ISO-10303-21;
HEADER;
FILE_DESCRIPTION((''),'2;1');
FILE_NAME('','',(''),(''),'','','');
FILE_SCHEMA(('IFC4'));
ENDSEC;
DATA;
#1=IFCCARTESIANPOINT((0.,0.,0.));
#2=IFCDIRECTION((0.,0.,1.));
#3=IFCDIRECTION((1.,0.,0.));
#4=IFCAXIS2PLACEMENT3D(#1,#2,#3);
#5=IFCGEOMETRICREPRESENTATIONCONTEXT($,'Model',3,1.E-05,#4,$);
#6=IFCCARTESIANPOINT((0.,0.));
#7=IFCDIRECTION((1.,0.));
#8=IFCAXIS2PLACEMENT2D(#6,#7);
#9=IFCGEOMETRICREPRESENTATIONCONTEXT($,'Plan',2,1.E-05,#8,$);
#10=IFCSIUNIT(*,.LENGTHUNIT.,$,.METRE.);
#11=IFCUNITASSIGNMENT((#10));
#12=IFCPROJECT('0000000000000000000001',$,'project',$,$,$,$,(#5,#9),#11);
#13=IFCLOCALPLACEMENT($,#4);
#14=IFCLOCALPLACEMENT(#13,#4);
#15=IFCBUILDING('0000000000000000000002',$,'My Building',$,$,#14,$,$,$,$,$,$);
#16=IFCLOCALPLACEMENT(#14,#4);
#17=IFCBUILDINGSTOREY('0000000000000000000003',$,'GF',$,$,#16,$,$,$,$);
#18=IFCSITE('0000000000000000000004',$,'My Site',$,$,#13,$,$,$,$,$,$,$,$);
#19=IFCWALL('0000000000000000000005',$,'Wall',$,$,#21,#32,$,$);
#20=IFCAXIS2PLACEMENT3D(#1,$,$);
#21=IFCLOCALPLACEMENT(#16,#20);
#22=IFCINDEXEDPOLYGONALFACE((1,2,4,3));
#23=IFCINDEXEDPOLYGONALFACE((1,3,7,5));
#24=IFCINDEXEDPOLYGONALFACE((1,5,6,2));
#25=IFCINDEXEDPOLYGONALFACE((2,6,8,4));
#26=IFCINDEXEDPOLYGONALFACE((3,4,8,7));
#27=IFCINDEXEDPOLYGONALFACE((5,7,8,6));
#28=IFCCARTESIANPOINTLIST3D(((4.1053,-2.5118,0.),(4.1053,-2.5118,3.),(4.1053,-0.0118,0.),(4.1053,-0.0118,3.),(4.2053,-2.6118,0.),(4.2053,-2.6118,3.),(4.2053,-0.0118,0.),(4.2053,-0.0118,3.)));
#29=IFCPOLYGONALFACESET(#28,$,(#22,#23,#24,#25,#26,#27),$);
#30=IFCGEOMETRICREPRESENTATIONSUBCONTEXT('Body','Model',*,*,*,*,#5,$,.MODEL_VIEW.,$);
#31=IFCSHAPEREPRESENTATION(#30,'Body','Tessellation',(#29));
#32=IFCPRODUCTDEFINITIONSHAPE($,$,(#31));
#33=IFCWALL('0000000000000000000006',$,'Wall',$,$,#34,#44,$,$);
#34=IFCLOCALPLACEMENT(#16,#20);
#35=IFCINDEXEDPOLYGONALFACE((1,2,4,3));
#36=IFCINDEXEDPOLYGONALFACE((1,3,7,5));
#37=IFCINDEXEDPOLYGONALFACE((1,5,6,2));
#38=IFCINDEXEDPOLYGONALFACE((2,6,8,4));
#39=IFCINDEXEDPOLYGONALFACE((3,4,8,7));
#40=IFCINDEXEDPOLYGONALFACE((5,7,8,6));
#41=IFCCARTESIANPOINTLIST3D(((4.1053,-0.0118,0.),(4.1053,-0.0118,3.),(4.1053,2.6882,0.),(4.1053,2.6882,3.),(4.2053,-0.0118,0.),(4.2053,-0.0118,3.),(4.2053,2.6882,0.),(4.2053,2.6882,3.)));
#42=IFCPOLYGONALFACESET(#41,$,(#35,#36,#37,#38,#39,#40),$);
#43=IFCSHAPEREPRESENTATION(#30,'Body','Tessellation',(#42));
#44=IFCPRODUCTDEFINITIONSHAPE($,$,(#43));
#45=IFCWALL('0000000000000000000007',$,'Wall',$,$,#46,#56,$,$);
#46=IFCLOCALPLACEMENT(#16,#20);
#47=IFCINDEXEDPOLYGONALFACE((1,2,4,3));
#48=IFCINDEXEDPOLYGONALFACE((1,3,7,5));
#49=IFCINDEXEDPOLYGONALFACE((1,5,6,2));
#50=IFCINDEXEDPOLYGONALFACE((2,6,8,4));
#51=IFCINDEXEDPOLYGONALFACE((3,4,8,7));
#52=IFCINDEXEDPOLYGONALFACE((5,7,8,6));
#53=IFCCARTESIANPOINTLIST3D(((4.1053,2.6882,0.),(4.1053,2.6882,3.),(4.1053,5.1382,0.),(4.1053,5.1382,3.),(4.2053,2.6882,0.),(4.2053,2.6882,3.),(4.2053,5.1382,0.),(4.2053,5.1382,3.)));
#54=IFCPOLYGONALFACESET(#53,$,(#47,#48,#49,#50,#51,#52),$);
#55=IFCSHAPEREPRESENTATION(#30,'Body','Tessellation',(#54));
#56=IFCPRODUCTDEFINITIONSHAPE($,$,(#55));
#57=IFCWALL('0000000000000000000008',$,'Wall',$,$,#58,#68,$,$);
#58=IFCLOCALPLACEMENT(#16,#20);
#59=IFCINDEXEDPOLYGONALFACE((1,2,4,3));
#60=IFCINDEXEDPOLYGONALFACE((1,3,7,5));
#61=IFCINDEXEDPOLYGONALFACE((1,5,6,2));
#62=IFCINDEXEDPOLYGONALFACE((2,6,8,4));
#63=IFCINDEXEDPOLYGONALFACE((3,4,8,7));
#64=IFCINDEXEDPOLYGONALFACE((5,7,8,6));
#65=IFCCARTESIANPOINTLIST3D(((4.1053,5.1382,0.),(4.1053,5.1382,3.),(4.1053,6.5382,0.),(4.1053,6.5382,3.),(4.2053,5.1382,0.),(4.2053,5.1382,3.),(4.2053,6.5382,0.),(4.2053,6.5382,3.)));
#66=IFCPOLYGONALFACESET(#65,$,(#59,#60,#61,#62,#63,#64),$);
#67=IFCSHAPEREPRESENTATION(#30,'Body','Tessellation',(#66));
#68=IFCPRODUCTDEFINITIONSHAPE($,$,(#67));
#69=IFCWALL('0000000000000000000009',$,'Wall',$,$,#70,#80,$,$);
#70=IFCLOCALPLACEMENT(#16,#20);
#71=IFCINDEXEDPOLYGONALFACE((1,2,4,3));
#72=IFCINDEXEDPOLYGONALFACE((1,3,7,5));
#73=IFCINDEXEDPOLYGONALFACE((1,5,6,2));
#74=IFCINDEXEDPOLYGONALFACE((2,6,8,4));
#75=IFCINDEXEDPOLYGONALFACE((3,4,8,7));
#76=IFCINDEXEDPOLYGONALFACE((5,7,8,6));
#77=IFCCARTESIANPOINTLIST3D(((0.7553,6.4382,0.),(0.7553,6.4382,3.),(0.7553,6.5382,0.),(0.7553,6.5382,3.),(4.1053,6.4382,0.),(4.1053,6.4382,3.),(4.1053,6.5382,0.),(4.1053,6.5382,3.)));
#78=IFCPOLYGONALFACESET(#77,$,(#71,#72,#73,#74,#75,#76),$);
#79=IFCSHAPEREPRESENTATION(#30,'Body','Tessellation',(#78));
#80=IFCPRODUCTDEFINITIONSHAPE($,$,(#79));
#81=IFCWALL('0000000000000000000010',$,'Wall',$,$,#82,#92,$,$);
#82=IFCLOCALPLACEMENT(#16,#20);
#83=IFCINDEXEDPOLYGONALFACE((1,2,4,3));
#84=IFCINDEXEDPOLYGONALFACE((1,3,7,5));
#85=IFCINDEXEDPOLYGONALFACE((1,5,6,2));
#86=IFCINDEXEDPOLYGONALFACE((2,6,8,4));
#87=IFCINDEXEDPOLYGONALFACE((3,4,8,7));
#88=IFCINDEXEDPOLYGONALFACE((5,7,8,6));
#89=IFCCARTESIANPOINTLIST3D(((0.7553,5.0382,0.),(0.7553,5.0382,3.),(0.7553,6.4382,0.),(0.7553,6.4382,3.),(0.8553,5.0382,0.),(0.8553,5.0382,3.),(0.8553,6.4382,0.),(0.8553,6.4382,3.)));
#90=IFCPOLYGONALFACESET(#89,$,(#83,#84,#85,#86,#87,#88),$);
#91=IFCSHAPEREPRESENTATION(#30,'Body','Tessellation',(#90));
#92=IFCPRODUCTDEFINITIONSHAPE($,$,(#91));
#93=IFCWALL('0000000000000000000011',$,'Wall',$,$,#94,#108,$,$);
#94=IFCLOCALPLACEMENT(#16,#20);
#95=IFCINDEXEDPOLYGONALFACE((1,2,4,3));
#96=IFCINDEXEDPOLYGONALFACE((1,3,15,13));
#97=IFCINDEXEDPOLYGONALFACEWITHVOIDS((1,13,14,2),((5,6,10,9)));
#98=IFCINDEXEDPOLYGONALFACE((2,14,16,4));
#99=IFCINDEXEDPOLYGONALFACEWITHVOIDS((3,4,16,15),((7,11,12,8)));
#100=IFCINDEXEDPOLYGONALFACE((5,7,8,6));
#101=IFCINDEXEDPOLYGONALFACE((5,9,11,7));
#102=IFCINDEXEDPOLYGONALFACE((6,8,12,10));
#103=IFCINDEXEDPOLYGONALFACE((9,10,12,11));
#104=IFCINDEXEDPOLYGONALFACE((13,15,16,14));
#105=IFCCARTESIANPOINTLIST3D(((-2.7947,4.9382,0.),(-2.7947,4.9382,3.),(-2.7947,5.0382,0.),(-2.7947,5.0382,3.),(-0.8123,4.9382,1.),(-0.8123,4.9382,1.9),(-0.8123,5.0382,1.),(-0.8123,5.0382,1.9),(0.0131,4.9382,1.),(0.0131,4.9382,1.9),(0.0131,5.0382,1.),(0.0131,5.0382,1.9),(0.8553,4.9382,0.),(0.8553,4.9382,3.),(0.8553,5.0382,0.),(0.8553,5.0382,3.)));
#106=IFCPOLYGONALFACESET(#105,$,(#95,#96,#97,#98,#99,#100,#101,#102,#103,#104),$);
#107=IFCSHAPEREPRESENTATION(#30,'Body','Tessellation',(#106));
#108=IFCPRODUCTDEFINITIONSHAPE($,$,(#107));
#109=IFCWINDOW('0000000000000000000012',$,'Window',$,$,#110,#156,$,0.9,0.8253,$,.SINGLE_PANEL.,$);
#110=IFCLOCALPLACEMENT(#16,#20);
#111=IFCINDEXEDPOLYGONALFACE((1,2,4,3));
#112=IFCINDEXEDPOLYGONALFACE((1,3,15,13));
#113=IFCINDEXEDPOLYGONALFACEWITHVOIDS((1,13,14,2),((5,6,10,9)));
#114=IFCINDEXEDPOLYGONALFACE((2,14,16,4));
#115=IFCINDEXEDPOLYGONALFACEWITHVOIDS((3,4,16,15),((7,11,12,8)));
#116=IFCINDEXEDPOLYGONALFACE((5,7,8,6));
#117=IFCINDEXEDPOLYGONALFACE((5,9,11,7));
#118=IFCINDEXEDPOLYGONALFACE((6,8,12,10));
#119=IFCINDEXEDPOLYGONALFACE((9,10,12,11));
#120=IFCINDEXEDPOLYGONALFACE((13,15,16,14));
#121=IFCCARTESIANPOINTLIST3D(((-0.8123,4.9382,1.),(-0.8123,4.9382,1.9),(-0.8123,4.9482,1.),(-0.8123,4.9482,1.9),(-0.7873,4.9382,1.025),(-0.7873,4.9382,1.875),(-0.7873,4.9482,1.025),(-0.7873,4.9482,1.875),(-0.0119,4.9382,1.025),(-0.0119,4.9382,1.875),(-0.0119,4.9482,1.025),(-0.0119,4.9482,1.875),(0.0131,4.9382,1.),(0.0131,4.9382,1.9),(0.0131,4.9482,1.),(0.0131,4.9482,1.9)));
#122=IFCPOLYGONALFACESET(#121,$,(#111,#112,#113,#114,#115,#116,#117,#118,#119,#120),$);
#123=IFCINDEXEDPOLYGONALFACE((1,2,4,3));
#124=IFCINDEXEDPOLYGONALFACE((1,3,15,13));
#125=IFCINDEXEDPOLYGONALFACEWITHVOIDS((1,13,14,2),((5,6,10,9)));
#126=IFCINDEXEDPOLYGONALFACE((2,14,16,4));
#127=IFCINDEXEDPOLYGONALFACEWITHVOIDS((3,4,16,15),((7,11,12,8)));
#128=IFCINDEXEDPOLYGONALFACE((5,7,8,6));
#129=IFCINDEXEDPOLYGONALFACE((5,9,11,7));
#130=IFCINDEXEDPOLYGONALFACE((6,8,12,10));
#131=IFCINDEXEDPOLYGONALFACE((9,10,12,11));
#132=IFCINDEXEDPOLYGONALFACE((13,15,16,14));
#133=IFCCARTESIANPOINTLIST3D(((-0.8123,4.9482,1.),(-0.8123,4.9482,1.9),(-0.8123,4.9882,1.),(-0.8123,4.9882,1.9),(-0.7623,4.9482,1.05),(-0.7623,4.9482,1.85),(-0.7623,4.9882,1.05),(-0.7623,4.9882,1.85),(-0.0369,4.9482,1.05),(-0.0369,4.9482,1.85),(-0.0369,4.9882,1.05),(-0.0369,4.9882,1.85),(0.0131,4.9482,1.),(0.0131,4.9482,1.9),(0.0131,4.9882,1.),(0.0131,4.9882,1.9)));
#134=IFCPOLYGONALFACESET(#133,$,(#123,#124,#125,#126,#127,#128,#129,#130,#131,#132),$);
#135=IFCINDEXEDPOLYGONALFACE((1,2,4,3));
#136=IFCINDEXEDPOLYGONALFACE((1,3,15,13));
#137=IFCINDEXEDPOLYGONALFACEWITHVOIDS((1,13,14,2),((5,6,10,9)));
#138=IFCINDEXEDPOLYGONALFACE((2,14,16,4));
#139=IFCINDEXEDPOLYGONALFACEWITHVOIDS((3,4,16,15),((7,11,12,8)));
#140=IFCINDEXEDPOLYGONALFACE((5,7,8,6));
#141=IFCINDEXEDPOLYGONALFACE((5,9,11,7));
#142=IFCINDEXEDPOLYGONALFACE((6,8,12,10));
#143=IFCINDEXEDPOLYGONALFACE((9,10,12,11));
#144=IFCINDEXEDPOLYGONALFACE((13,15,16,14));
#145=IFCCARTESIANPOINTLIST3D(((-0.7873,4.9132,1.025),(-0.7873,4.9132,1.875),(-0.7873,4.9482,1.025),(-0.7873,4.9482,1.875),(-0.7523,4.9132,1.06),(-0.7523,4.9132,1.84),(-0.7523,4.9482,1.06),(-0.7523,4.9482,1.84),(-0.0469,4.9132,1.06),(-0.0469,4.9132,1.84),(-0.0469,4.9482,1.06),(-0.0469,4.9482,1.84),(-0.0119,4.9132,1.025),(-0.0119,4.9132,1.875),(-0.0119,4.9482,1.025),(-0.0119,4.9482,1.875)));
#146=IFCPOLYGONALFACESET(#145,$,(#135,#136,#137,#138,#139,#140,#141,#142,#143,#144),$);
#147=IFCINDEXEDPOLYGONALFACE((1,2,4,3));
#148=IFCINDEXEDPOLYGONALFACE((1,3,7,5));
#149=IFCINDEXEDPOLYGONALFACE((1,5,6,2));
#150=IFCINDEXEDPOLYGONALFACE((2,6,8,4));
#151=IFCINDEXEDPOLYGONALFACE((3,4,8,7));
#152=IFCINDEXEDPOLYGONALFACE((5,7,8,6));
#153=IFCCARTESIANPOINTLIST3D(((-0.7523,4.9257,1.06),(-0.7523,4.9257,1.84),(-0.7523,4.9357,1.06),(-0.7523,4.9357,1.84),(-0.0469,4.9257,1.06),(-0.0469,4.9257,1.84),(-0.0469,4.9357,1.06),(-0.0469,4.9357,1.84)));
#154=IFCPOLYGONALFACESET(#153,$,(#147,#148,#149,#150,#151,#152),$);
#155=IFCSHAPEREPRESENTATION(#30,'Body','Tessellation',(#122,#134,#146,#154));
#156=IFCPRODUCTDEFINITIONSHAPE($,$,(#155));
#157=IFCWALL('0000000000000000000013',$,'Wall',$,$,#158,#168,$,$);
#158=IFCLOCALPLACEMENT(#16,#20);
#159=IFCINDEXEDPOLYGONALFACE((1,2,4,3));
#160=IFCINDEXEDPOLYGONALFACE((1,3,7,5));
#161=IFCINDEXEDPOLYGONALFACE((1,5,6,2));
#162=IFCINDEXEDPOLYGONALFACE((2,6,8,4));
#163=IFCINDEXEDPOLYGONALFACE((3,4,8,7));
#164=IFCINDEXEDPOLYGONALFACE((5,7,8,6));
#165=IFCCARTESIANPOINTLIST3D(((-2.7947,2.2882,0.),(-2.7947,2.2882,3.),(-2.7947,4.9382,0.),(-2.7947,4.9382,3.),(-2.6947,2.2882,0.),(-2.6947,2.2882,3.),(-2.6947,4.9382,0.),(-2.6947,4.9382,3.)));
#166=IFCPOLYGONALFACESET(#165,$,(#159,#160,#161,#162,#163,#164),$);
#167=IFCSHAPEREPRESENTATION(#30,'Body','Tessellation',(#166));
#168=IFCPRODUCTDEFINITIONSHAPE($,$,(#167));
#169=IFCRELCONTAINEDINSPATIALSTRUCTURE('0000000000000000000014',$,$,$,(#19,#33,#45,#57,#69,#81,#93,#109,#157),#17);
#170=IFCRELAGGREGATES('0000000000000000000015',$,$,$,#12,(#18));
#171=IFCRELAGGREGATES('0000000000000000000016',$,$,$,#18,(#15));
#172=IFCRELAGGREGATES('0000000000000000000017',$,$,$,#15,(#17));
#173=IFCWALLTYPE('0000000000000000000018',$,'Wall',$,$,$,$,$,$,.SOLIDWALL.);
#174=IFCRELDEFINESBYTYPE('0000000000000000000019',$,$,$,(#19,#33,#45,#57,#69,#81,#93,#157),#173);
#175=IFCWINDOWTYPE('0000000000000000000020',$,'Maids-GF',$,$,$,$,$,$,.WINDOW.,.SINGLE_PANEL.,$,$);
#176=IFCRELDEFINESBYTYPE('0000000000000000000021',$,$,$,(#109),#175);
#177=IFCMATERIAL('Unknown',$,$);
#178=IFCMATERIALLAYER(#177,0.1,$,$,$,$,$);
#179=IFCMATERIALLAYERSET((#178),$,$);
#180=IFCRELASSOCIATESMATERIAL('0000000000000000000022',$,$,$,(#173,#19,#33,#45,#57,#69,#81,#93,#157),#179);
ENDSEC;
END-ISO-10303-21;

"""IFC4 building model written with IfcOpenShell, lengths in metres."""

from ifc_helpers import new_model, entity, si_unit, frame, origin_with_axes, origin_2d_with_axis, place, context, subcontext, project, spatial, line, indexed_curve, outline, extrude, shape, source, transform, mapped, material, layer, layer_set, layer_usage, type_object, type_shapes, element, fill, save


model = new_model("IFC4")

# Units and contexts
model_context = context("Model", 3, precision=1e-05, world=origin_with_axes())
plan_context = context("Plan", 2, precision=1e-05, world=origin_2d_with_axis())
body_context_1 = subcontext(model_context, "Body", "Model", "MODEL_VIEW")
body_context_2 = subcontext(plan_context, "Body", "Plan", "PLAN_VIEW")
ifc_project = project(units=[si_unit("LENGTHUNIT", "METRE")], contexts=[model_context, plan_context])

# Site, building, storey
site_placement = place(None, origin_with_axes())
site = spatial("IfcSite", under=ifc_project, at=site_placement, Name="My Site")
building_placement = place(site_placement, origin_with_axes())
building = spatial("IfcBuilding", under=site, at=building_placement, Name="My Building")
storey_placement = place(building_placement, origin_with_axes())
storey = spatial("IfcBuildingStorey", under=building, at=storey_placement, Name="GF")

# Shared definitions
ifc_material = material(Name="Unknown")

# Shared definitions
ifc_layer_1 = layer(ifc_material, 0.1)
ifc_layer_set_1 = layer_set([ifc_layer_1])
wall_type = type_object("IfcWallType", Name="Wall", PredefinedType="SOLIDWALL", material=ifc_layer_set_1)

# Walls
ifc_layer_usage_1 = layer_usage(ifc_layer_set_1, "AXIS2", "POSITIVE", 0.0)
wall_1_placement = place(storey_placement, frame((4.2053, -2.6118, 0.0), z_axis=(0.0, 0.0, 1.0), x_axis=(0.0, 1.0, 0.0)))
element("IfcWall", 1, at=wall_1_placement, inside=storey, type_object=wall_type, material=ifc_layer_usage_1, Name="Wall", context=body_context_1, shape_type="SweptSolid", body=[
    extrude(outline(indexed_curve([(0.0, 0.0), (0.1, 0.1), (2.6, 0.1), (2.6, 0.0)], segments=[line(1, 2, 3, 4, 1)])), origin_with_axes(), (0.0, 0.0, 1.0), 3.0),
])
ifc_layer_usage_2 = layer_usage(ifc_layer_set_1, "AXIS2", "POSITIVE", 0.0)
wall_2_placement = place(storey_placement, frame((4.2053, -0.0118, 0.0), z_axis=(0.0, 0.0, 1.0), x_axis=(0.0, 1.0, 0.0)))
element("IfcWall", 2, at=wall_2_placement, inside=storey, type_object=wall_type, material=ifc_layer_usage_2, Name="Wall", context=body_context_1, shape_type="SweptSolid", body=[
    extrude(outline(indexed_curve([(0.0, 0.0), (0.0, 0.1), (2.7, 0.1), (2.7, 0.0)], segments=[line(1, 2, 3, 4, 1)])), origin_with_axes(), (0.0, 0.0, 1.0), 3.0),
])
ifc_layer_usage_3 = layer_usage(ifc_layer_set_1, "AXIS2", "POSITIVE", 0.0)
wall_3_placement = place(storey_placement, frame((4.2053, 2.6882, 0.0), z_axis=(0.0, 0.0, 1.0), x_axis=(0.0, 1.0, 0.0)))
element("IfcWall", 3, at=wall_3_placement, inside=storey, type_object=wall_type, material=ifc_layer_usage_3, Name="Wall", context=body_context_1, shape_type="SweptSolid", body=[
    extrude(outline(indexed_curve([(0.0, 0.0), (0.0, 0.1), (2.45, 0.1), (2.45, 0.0)], segments=[line(1, 2, 3, 4, 1)])), origin_with_axes(), (0.0, 0.0, 1.0), 3.0),
])
ifc_layer_usage_4 = layer_usage(ifc_layer_set_1, "AXIS2", "POSITIVE", 0.0)
wall_4_placement = place(storey_placement, frame((4.2053, 5.1382, 0.0), z_axis=(0.0, 0.0, 1.0), x_axis=(0.0, 1.0, 0.0)))
element("IfcWall", 4, at=wall_4_placement, inside=storey, type_object=wall_type, material=ifc_layer_usage_4, Name="Wall", context=body_context_1, shape_type="SweptSolid", body=[
    extrude(outline(indexed_curve([(0.0, 0.0), (0.0, 0.1), (1.4, 0.1), (1.4, 0.0)], segments=[line(1, 2, 3, 4, 1)])), origin_with_axes(), (0.0, 0.0, 1.0), 3.0),
])
ifc_layer_usage_5 = layer_usage(ifc_layer_set_1, "AXIS2", "POSITIVE", 0.0)
wall_5_placement = place(storey_placement, frame((4.1053, 6.5382, 0.0), z_axis=(0.0, 0.0, 1.0), x_axis=(-1.0, 0.0, 0.0)))
element("IfcWall", 5, at=wall_5_placement, inside=storey, type_object=wall_type, material=ifc_layer_usage_5, Name="Wall", context=body_context_1, shape_type="SweptSolid", body=[
    extrude(outline(indexed_curve([(0.0, 0.0), (0.0, 0.1), (3.35, 0.1), (3.35, 0.0)], segments=[line(1, 2, 3, 4, 1)])), origin_with_axes(), (0.0, 0.0, 1.0), 3.0),
])
ifc_layer_usage_6 = layer_usage(ifc_layer_set_1, "AXIS2", "POSITIVE", 0.0)
wall_6_placement = place(storey_placement, frame((0.7553, 6.4382, 0.0), z_axis=(0.0, 0.0, 1.0), x_axis=(0.0, -1.0, 0.0)))
element("IfcWall", 6, at=wall_6_placement, inside=storey, type_object=wall_type, material=ifc_layer_usage_6, Name="Wall", context=body_context_1, shape_type="SweptSolid", body=[
    extrude(outline(indexed_curve([(0.0, 0.0), (0.0, 0.1), (1.4, 0.1), (1.4, 0.0)], segments=[line(1, 2, 3, 4, 1)])), origin_with_axes(), (0.0, 0.0, 1.0), 3.0),
])

# Wall, opening, window
ifc_layer_usage_7 = layer_usage(ifc_layer_set_1, "AXIS2", "POSITIVE", 0.0)
wall_7_placement = place(storey_placement, frame((0.8553, 5.0382, 0.0), z_axis=(0.0, 0.0, 1.0), x_axis=(-1.0, 0.0, 0.0)))
wall_7 = element("IfcWall", 7, at=wall_7_placement, inside=storey, type_object=wall_type, material=ifc_layer_usage_7, Name="Wall", context=body_context_1, shape_type="SweptSolid", body=[
    extrude(outline(indexed_curve([(0.0, 0.0), (0.0, 0.1), (3.65, 0.1), (3.65, 0.0)], segments=[line(1, 2, 3, 4, 1)])), origin_with_axes(), (0.0, 0.0, 1.0), 3.0),
])
shared_shape_1 = source(origin_with_axes(), body_context_1, "Body", "SweptSolid", [
    extrude(outline(indexed_curve([(0.0, 0.0), (0.8253, 0.0), (0.8253, 0.9), (0.0, 0.9)], segments=[line(1, 2, 3, 4, 1)])), frame((0.0, -0.6, 0.0), z_axis=(0.0, -1.0, 0.0), x_axis=(1.0, 0.0, 0.0)), (0.0, 0.0, -1.0), 1.2),
])
opening_1_placement = place(wall_7_placement, frame((0.8422, 0.0, 1.0), z_axis=(0.0, 0.0, 1.0), x_axis=(1.0, -0.000001, 0.0)))
opening_1 = element("IfcOpeningElement", 8, at=opening_1_placement, cuts=wall_7, PredefinedType="OPENING", context=body_context_1, shape_type="MappedRepresentation", body=[
    mapped(shared_shape_1, transform((0.0, 0.0, 0.0), x_axis=(1.0, 0.0, 0.0), y_axis=(0.0, 1.0, 0.0), z_axis=(0.0, 0.0, 1.0), scale=1.0)),
])
window_type_1 = type_object("IfcWindowType", Name="Maids-GF", PartitioningType="SINGLE_PANEL", PredefinedType="WINDOW")
shared_shape_2 = source(origin_with_axes(), body_context_1, "Body", "SweptSolid", [
    extrude(outline(indexed_curve([(0.0, 0.0), (0.8253, 0.0), (0.8253, 0.9), (0.0, 0.9)], segments=[line(1, 2, 3, 4, 1)]), holes=[indexed_curve([(0.025, 0.025), (0.8003, 0.025), (0.8003, 0.875), (0.025, 0.875)], segments=[line(1, 2, 3, 4, 1)])]), frame((0.0, 0.09, 0.0), z_axis=(0.0, -1.0, 0.0), x_axis=(1.0, 0.0, 0.0)), (0.0, 0.0, -1.0), 0.01),
    extrude(outline(indexed_curve([(0.0, 0.0), (0.8253, 0.0), (0.8253, 0.9), (0.0, 0.9)], segments=[line(1, 2, 3, 4, 1)]), holes=[indexed_curve([(0.05, 0.05), (0.7753, 0.05), (0.7753, 0.85), (0.05, 0.85)], segments=[line(1, 2, 3, 4, 1)])]), frame((0.0, 0.05, 0.0), z_axis=(0.0, -1.0, 0.0), x_axis=(1.0, 0.0, 0.0)), (0.0, 0.0, -1.0), 0.04),
    extrude(outline(indexed_curve([(0.0, 0.0), (0.7753, 0.0), (0.7753, 0.85), (0.0, 0.85)], segments=[line(1, 2, 3, 4, 1)]), holes=[indexed_curve([(0.035, 0.035), (0.7403, 0.035), (0.7403, 0.815), (0.035, 0.815)], segments=[line(1, 2, 3, 4, 1)])]), frame((0.025, 0.09, 0.025), z_axis=(0.0, -1.0, 0.0), x_axis=(1.0, 0.0, 0.0)), (0.0, 0.0, -1.0), 0.035),
    extrude(outline(indexed_curve([(0.035, 0.035), (0.7403, 0.035), (0.7403, 0.815), (0.035, 0.815)], segments=[line(1, 2, 3, 4, 1)])), frame((0.025, 0.1025, 0.025), z_axis=(0.0, -1.0, 0.0), x_axis=(1.0, 0.0, 0.0)), (0.0, 0.0, -1.0), 0.01),
])
shared_shape_3 = source(origin_with_axes(), body_context_2, "Body", "Curve2D", [
    entity("IfcIndexedPolyCurve", entity("IfcCartesianPointList2D", [[0.05, 0.05], [0.7753, 0.05]])),
    entity("IfcIndexedPolyCurve", entity("IfcCartesianPointList2D", [[0.0, 0.1], [0.025, 0.1], [0.025, 0.09], [0.05, 0.09], [0.05, 0.05], [0.0, 0.05]]), [entity("IfcLineIndex", [1, 2, 3, 4, 5, 6, 1])]),
    entity("IfcIndexedPolyCurve", entity("IfcCartesianPointList2D", [[0.8253, 0.1], [0.8003, 0.1], [0.8003, 0.09], [0.7753, 0.09], [0.7753, 0.05], [0.8253, 0.05]]), [entity("IfcLineIndex", [1, 2, 3, 4, 5, 6, 1])]),
    entity("IfcIndexedPolyCurve", entity("IfcCartesianPointList2D", [[0.025, 0.09], [0.06, 0.09], [0.06, 0.125], [0.025, 0.125]]), [entity("IfcLineIndex", [1, 2, 3, 4, 1])]),
    entity("IfcIndexedPolyCurve", entity("IfcCartesianPointList2D", [[0.8003, 0.09], [0.7653, 0.09], [0.7653, 0.125], [0.8003, 0.125]]), [entity("IfcLineIndex", [1, 2, 3, 4, 1])]),
    entity("IfcIndexedPolyCurve", entity("IfcCartesianPointList2D", [[0.06, 0.09], [0.7653, 0.09]])),
    entity("IfcIndexedPolyCurve", entity("IfcCartesianPointList2D", [[0.06, 0.125], [0.7653, 0.125]])),
    entity("IfcIndexedPolyCurve", entity("IfcCartesianPointList2D", [[0.06, 0.1075], [0.7653, 0.1075]])),
])
type_shapes(window_type_1, [shared_shape_2, shared_shape_3])
window_1_placement = place(opening_1_placement, frame((0.0, 0.0, 0.0), z_axis=(0.0, 0.0, 1.0), x_axis=(1.0, 0.0, 0.0)))
window_1 = element("IfcWindow", 9, at=window_1_placement, inside=storey, type_object=window_type_1, Name="Window", OverallHeight=0.9, OverallWidth=0.8253, PartitioningType="SINGLE_PANEL", shapes=[
    shape(body_context_1, "Body", "MappedRepresentation", [mapped(shared_shape_2, transform((0.0, 0.0, 0.0), x_axis=(1.0, 0.0, 0.0), y_axis=(0.0, 1.0, 0.0), z_axis=(0.0, 0.0, 1.0), scale=1.0))]),
    shape(body_context_2, "Body", "MappedRepresentation", [mapped(shared_shape_3, transform((0.0, 0.0, 0.0), x_axis=(1.0, 0.0, 0.0), y_axis=(0.0, 1.0, 0.0), z_axis=(0.0, 0.0, 1.0), scale=1.0))]),
])
fill(opening_1, window_1)

# Wall
ifc_layer_usage_8 = layer_usage(ifc_layer_set_1, "AXIS2", "POSITIVE", 0.0)
wall_8_placement = place(storey_placement, frame((-2.7947, 4.9382, 0.0), z_axis=(0.0, 0.0, 1.0), x_axis=(0.0, -1.0, 0.0)))
element("IfcWall", 10, at=wall_8_placement, inside=storey, type_object=wall_type, material=ifc_layer_usage_8, Name="Wall", context=body_context_1, shape_type="SweptSolid", body=[
    extrude(outline(indexed_curve([(0.0, 0.0), (0.0, 0.1), (2.65, 0.1), (2.65, 0.0)], segments=[line(1, 2, 3, 4, 1)])), origin_with_axes(), (0.0, 0.0, 1.0), 3.0),
])

save(model, "model.ifc")
